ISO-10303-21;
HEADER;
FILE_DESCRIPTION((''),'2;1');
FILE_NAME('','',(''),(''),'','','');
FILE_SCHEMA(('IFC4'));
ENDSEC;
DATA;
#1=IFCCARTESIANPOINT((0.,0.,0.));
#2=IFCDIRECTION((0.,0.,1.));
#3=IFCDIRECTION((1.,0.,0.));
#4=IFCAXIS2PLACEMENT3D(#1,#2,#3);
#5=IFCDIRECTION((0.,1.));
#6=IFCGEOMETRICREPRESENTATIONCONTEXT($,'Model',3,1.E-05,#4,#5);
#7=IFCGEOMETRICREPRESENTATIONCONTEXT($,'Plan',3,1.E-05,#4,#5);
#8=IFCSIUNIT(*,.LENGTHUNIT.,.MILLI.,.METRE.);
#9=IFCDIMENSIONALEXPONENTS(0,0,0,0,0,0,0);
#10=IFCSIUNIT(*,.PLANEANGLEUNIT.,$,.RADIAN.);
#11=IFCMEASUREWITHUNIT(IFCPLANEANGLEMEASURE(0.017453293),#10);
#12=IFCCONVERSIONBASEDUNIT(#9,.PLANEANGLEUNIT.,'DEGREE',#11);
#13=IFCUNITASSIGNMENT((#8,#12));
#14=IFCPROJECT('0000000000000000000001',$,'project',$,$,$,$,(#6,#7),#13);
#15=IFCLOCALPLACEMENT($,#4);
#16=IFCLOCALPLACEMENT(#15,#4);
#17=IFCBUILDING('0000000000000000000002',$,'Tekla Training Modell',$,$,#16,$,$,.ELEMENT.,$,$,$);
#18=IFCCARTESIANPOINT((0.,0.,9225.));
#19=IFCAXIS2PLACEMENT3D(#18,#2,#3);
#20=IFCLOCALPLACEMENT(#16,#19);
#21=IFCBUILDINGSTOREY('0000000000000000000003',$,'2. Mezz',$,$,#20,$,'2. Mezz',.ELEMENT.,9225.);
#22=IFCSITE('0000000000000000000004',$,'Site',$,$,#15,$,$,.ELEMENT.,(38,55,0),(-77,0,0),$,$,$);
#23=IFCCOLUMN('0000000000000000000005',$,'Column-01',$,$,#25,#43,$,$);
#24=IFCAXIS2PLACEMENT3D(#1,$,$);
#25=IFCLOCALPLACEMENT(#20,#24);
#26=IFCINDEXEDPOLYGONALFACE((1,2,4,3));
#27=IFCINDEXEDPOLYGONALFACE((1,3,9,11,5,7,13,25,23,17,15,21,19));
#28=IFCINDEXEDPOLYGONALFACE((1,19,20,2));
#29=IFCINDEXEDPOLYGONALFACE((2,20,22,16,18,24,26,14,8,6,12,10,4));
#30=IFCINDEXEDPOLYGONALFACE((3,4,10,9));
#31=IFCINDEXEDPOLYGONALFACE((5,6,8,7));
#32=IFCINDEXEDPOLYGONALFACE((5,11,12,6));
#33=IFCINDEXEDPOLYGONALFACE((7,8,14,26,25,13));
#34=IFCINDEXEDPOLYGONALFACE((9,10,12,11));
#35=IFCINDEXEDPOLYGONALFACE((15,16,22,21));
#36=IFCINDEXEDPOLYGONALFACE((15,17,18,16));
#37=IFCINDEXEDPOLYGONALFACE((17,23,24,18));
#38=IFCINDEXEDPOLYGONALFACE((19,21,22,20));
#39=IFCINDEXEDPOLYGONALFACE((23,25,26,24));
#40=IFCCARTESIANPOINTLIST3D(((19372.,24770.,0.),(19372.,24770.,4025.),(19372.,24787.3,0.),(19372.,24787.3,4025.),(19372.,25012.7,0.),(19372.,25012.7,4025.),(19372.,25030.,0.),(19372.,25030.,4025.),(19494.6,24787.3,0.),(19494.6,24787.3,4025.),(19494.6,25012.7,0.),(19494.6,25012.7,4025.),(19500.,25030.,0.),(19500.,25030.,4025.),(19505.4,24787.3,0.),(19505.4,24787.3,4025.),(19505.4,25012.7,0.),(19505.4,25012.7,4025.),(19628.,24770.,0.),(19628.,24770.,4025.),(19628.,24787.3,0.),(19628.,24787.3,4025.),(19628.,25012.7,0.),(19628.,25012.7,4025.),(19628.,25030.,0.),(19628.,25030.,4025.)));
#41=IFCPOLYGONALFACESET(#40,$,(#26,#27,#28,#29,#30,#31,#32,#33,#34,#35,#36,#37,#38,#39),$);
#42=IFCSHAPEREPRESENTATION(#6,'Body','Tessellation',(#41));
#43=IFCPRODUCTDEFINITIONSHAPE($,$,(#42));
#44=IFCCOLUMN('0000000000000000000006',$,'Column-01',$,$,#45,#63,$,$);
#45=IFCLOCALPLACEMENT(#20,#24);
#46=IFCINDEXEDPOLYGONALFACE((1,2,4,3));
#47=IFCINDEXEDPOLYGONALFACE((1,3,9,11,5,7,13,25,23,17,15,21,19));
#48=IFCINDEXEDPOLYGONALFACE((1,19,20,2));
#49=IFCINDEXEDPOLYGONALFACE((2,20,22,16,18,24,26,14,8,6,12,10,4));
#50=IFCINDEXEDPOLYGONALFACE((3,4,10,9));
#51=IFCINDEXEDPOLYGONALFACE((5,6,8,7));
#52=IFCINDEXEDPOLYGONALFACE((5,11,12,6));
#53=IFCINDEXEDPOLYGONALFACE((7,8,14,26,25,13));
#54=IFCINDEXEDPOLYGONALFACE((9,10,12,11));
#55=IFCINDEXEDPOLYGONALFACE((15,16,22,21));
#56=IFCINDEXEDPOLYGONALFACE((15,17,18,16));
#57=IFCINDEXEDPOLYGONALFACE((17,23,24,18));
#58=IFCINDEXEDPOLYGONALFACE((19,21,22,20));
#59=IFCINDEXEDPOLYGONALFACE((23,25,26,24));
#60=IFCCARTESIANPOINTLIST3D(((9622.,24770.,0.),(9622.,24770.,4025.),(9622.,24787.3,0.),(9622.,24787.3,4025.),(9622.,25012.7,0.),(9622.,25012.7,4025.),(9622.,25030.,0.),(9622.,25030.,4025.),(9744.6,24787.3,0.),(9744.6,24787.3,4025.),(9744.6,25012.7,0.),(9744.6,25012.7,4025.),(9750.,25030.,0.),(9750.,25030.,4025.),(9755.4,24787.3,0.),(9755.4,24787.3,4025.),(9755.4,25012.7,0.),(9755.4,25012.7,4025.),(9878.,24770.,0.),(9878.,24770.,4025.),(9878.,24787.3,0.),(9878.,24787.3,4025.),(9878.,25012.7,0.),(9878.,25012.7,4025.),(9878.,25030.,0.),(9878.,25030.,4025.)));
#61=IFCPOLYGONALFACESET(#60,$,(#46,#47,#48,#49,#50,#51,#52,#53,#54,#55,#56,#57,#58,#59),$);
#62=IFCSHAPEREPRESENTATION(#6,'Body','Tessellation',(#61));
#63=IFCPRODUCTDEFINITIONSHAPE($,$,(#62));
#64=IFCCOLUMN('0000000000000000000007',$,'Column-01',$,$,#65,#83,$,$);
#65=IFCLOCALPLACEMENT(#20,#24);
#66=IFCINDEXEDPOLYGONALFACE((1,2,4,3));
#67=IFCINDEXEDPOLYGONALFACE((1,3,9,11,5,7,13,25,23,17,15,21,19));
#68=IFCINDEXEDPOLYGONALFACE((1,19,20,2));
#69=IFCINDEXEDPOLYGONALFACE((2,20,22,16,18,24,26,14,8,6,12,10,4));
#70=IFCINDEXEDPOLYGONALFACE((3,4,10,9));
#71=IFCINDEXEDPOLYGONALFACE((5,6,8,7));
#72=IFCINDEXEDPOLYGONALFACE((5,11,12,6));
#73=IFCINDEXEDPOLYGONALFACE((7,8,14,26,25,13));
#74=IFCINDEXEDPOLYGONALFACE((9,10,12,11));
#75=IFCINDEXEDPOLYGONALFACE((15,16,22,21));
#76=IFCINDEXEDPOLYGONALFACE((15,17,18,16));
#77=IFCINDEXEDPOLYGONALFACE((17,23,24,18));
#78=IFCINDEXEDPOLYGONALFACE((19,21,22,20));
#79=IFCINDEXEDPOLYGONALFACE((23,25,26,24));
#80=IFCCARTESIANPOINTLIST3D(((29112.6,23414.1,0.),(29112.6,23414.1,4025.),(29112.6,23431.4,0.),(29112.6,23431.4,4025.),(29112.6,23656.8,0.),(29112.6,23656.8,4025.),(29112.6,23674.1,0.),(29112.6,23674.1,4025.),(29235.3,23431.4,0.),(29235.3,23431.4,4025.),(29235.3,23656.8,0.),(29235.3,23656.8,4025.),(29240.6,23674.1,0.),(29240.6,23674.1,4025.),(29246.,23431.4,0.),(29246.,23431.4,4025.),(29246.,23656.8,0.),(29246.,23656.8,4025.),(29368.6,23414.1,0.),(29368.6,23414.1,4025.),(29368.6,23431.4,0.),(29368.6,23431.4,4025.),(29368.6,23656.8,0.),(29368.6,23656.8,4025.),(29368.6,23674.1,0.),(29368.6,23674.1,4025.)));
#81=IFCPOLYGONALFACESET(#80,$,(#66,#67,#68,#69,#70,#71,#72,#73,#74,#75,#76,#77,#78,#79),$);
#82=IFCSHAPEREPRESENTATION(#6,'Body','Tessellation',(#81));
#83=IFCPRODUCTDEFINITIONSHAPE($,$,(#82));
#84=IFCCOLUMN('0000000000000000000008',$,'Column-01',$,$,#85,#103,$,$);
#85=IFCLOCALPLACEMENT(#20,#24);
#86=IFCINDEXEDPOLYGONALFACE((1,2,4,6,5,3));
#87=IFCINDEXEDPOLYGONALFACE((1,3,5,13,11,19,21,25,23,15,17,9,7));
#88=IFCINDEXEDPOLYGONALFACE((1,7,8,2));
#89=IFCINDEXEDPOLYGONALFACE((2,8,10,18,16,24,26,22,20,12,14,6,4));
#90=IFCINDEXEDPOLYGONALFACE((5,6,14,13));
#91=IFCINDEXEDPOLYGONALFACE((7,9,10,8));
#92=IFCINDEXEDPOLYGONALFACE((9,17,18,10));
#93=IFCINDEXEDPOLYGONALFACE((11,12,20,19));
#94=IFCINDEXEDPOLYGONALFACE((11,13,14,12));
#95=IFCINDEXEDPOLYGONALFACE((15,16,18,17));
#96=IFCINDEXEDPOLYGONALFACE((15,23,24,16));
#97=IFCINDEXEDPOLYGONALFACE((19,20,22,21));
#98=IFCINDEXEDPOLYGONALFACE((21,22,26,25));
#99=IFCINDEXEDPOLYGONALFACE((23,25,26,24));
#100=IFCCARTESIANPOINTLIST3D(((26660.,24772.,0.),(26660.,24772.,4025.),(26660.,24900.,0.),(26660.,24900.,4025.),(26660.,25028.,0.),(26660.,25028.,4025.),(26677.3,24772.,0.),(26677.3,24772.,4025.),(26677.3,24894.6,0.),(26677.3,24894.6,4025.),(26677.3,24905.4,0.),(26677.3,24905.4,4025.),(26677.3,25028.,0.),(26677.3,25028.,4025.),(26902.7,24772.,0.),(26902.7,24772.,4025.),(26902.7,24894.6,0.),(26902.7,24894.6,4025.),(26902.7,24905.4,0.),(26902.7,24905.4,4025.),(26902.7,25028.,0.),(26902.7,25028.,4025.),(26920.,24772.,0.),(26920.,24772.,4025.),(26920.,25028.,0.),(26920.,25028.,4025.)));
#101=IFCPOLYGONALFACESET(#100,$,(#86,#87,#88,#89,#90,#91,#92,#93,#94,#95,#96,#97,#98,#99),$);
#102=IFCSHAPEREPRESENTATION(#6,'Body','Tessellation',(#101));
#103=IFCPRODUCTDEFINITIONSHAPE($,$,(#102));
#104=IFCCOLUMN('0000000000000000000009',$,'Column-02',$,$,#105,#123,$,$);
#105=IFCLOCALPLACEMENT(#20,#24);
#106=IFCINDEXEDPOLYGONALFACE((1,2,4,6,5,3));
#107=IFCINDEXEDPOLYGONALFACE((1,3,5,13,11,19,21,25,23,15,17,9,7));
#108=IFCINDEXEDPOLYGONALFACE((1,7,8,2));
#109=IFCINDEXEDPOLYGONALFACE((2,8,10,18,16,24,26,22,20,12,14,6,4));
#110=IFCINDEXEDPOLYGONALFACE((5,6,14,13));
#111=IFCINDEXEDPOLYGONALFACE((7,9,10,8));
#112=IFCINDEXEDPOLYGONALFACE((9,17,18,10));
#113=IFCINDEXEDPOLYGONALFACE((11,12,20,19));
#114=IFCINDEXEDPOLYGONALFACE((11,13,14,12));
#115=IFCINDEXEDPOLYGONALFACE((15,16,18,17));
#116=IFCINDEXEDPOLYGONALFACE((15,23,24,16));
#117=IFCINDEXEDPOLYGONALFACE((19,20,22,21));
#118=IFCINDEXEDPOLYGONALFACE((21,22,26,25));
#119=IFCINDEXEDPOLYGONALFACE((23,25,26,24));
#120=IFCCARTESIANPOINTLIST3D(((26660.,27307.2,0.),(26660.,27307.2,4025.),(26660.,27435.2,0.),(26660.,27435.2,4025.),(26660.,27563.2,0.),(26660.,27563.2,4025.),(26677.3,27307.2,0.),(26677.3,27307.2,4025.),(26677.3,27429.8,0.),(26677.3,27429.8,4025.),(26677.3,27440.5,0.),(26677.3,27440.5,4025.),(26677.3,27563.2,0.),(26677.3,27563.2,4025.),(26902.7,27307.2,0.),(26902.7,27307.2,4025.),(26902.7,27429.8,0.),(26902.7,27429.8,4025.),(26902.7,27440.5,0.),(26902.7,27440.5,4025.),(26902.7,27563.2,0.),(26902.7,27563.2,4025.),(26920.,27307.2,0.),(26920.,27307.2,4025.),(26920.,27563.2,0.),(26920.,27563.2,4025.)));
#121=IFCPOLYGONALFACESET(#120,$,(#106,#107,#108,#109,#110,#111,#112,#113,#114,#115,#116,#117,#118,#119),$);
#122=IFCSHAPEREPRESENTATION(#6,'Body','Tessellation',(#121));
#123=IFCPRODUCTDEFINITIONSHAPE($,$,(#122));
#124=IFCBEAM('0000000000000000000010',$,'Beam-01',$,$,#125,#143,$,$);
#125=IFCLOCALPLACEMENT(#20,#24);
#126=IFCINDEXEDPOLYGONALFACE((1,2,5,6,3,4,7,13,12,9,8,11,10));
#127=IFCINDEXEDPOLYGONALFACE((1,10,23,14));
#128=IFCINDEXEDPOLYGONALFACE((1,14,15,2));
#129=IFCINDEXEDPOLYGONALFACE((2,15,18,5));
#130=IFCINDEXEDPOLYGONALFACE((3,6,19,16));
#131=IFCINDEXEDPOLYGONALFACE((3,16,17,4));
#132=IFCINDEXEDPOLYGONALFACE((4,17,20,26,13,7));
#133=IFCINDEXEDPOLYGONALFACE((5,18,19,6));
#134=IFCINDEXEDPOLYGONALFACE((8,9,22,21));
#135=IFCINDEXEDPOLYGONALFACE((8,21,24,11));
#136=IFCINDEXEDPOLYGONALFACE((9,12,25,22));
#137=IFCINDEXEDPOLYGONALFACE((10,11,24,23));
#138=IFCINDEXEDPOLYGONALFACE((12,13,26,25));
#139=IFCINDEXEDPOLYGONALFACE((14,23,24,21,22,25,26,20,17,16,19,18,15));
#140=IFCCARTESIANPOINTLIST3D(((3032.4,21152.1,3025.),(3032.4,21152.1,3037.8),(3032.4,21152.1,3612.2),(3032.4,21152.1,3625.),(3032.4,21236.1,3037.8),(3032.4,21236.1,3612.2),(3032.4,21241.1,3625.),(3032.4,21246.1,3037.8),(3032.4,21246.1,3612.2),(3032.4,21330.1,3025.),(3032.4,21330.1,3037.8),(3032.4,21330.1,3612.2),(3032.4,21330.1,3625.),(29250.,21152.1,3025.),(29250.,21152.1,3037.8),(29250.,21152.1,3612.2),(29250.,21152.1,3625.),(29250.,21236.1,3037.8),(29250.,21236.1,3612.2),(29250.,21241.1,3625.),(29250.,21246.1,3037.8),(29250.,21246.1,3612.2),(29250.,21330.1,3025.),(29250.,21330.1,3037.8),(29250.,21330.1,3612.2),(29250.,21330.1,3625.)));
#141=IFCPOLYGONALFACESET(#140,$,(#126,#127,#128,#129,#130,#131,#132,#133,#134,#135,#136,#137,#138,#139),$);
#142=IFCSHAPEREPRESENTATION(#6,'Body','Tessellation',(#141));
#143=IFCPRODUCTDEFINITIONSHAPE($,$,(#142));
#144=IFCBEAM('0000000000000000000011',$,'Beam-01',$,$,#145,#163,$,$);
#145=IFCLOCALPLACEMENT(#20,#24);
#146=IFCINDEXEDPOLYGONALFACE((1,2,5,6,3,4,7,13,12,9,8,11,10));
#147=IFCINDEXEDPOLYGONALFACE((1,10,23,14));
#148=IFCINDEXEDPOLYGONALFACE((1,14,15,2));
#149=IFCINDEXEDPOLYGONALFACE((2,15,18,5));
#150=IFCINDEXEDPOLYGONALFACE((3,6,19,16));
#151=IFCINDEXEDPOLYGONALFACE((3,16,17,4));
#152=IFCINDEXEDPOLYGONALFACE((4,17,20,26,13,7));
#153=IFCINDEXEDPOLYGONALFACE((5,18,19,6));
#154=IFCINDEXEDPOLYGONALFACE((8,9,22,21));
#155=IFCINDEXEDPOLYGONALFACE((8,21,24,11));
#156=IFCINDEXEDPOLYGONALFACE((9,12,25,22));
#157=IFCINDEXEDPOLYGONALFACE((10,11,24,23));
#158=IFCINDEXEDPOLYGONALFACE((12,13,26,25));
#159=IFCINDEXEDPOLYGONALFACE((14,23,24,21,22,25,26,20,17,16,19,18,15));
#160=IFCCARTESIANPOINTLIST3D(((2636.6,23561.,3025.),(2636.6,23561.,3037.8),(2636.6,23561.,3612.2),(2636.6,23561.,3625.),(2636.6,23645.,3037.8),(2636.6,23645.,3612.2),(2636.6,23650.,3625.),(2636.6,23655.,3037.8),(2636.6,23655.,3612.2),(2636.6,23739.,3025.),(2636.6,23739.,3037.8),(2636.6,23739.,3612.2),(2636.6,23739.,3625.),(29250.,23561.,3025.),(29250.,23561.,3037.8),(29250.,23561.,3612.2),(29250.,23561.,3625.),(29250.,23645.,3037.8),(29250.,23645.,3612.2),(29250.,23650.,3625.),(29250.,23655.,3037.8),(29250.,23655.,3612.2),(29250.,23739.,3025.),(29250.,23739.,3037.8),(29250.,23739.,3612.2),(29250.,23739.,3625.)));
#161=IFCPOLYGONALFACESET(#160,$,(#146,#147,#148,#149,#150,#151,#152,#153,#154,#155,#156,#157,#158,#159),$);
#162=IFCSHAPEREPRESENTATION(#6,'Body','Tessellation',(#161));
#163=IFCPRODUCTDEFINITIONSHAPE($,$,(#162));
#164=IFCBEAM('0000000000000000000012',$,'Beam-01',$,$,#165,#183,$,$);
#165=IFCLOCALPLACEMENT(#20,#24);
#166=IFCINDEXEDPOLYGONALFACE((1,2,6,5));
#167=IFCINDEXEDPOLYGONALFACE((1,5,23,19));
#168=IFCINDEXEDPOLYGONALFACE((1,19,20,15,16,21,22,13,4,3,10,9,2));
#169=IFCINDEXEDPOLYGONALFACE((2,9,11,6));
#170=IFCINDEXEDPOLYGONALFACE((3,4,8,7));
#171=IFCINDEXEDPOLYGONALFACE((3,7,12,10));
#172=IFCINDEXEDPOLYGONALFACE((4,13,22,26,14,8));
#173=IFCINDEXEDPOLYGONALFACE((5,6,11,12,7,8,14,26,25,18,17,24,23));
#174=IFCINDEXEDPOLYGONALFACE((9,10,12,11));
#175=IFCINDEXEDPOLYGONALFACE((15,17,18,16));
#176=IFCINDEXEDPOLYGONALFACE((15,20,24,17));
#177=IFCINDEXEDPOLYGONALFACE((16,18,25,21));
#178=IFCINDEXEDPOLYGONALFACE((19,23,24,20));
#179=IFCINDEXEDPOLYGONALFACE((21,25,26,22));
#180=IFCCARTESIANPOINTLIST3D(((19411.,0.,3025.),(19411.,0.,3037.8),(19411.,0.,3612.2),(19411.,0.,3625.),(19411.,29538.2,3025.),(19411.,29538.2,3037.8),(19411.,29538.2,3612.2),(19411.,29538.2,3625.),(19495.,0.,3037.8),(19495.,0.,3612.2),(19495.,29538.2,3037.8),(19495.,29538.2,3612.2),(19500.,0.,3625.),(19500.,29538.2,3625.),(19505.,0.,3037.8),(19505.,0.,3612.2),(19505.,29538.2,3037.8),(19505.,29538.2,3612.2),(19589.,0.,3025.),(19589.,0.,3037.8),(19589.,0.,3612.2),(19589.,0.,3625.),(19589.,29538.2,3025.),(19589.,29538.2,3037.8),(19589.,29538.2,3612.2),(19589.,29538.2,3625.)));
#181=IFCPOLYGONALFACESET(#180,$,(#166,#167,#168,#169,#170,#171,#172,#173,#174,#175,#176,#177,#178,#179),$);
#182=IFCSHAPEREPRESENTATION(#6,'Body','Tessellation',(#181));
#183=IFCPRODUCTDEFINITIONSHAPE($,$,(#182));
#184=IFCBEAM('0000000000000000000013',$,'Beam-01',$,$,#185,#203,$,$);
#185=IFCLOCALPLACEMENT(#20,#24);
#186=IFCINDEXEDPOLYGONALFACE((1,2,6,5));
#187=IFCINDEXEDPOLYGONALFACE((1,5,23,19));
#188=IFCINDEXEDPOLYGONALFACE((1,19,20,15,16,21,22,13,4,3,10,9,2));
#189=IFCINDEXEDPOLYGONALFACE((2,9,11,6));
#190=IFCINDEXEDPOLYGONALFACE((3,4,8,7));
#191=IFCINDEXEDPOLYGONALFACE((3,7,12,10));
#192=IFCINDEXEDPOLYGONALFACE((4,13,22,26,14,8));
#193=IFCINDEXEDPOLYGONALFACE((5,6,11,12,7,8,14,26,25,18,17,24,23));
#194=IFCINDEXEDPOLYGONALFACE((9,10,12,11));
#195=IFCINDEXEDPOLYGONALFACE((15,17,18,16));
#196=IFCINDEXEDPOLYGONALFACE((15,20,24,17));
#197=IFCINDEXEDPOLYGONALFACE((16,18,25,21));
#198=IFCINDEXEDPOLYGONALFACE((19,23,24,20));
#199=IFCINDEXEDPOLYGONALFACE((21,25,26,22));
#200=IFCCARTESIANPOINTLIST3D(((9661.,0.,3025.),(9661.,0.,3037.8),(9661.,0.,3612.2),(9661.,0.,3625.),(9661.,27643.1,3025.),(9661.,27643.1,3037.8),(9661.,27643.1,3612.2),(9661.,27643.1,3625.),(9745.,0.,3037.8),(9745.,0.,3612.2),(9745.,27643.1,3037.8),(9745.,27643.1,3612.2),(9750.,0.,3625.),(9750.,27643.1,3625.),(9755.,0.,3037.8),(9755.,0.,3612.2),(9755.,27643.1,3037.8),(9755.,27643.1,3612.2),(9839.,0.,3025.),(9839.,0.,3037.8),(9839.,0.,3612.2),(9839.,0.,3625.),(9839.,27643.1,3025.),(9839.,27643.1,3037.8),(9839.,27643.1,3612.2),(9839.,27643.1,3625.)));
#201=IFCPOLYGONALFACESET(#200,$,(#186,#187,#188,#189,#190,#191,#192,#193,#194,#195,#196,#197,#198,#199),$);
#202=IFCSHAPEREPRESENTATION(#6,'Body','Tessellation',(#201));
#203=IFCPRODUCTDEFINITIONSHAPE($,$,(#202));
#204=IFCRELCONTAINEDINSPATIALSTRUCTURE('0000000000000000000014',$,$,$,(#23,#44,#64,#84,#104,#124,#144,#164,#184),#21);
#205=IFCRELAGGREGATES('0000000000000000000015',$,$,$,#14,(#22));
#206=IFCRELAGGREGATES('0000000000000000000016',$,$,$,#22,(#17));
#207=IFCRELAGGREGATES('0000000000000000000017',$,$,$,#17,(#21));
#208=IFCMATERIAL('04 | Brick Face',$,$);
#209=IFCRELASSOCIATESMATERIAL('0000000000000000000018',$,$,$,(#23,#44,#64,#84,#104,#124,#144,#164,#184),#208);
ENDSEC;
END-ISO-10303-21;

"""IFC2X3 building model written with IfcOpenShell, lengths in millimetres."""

from ifc_helpers import new_model, entity, si_unit, converted_unit, direction, frame, origin_with_axes, place, context, project, spatial, polyline, outline, extrude, material, element, save


model = new_model("IFC2X3")

# Units and contexts
model_context = context("Model", 3, precision=1e-05, world=origin_with_axes(), true_north=direction((0.0, 1.0)))
plan_context = context("Plan", 3, precision=1e-05, world=origin_with_axes(), true_north=direction((0.0, 1.0)))
ifc_project = project(units=[si_unit("LENGTHUNIT", "METRE", prefix="MILLI"), converted_unit("PLANEANGLEUNIT", "DEGREE", entity("IfcPlaneAngleMeasure", 0.017453293), si_unit("PLANEANGLEUNIT", "RADIAN"), dimensions=[0, 0, 0, 0, 0, 0, 0])], contexts=[model_context, plan_context])

# Site, building, storey
site_placement = place(None, origin_with_axes())
site = spatial("IfcSite", under=ifc_project, at=site_placement, Name="Site", CompositionType="ELEMENT", RefLatitude=(38, 55, 0), RefLongitude=(-77, 0, 0))
building_placement = place(site_placement, origin_with_axes())
building = spatial("IfcBuilding", under=site, at=building_placement, Name="Tekla Training Modell", CompositionType="ELEMENT")
storey_placement = place(building_placement, frame((0.0, 0.0, 9225.0), z_axis=(0.0, 0.0, 1.0), x_axis=(1.0, 0.0, 0.0)))
storey = spatial("IfcBuildingStorey", under=building, at=storey_placement, Name="2. Mezz", LongName="2. Mezz", CompositionType="ELEMENT", Elevation=9225.0)

# Columns
ifc_material_1 = material(Name="04 | Brick Face")
for number, where, z_axis, x_axis, name in (
    (1, (19500.0, 24900.0, 0.0), (0.0, 0.0, 1.0), (1.0, 0.0, 0.0), "Column-01"),
    (2, (9750.0, 24900.0, 0.0), (0.0, 0.0, 1.0), (1.0, 0.0, 0.0), "Column-01"),
    (3, (29240.6, 23544.1, 0.0), (0.0, 0.0, 1.0), (1.0, 0.0, 0.0), "Column-01"),
    (4, (26790.0, 24900.0, 0.0), (0.0, 0.0, 1.0), (0.0, 1.0, 0.0), "Column-01"),
    (5, (26790.0, 27435.2, 0.0), (0.0, 0.0, 1.0), (0.0, 1.0, 0.0), "Column-02"),
):
    element("IfcColumn", number, at=place(storey_placement, frame(where, z_axis=z_axis, x_axis=x_axis)), inside=storey, material=ifc_material_1, Name=name, context=model_context, shape_type="SweptSolid", body=[
        extrude(outline(polyline([(0.0, 130.0), (-128.0, 130.0), (-128.0, 112.7), (-5.3, 112.7), (-5.3, -112.7), (-128.0, -112.7), (-128.0, -130.0), (128.0, -130.0), (128.0, -112.7), (5.3, -112.7), (5.3, 112.7), (128.0, 112.7), (128.0, 130.0), (0.0, 130.0)])), origin_with_axes(), (0.0, 0.0, 1.0), 4025.0),
    ])

# Beams
beam_1_placement = place(storey_placement, frame((3032.4, 21241.1, 3325.0), z_axis=(0.0, 0.0, 1.0), x_axis=(0.0, -1.0, 0.0)))
element("IfcBeam", 6, at=beam_1_placement, inside=storey, material=ifc_material_1, Name="Beam-01", context=model_context, shape_type="SweptSolid", body=[
    extrude(outline(polyline([(0.0, 300.0), (-89.0, 300.0), (-89.0, 287.2), (-5.0, 287.2), (-5.0, -287.2), (-89.0, -287.2), (-89.0, -300.0), (89.0, -300.0), (89.0, -287.2), (5.0, -287.2), (5.0, 287.2), (89.0, 287.2), (89.0, 300.0), (0.0, 300.0)])), frame((0.0, 26217.6, 0.0), z_axis=(0.0, -1.0, 0.0), x_axis=(1.0, 0.0, 0.0)), (0.0, 0.0, 1.0), 26217.6),
])
beam_2_placement = place(storey_placement, frame((2636.6, 23650.0, 3325.0), z_axis=(0.0, 0.0, 1.0), x_axis=(0.0, -1.0, 0.0)))
element("IfcBeam", 7, at=beam_2_placement, inside=storey, material=ifc_material_1, Name="Beam-01", context=model_context, shape_type="SweptSolid", body=[
    extrude(outline(polyline([(0.0, 300.0), (-89.0, 300.0), (-89.0, 287.2), (-5.0, 287.2), (-5.0, -287.2), (-89.0, -287.2), (-89.0, -300.0), (89.0, -300.0), (89.0, -287.2), (5.0, -287.2), (5.0, 287.2), (89.0, 287.2), (89.0, 300.0), (0.0, 300.0)])), frame((0.0, 26613.4, 0.0), z_axis=(0.0, -1.0, 0.0), x_axis=(1.0, 0.0, 0.0)), (0.0, 0.0, 1.0), 26613.4),
])
beam_3_placement = place(storey_placement, frame((19500.0, 29538.2, 3325.0), z_axis=(0.0, 0.0, 1.0), x_axis=(-1.0, 0.0, 0.0)))
element("IfcBeam", 8, at=beam_3_placement, inside=storey, material=ifc_material_1, Name="Beam-01", context=model_context, shape_type="SweptSolid", body=[
    extrude(outline(polyline([(0.0, 300.0), (-89.0, 300.0), (-89.0, 287.2), (-5.0, 287.2), (-5.0, -287.2), (-89.0, -287.2), (-89.0, -300.0), (89.0, -300.0), (89.0, -287.2), (5.0, -287.2), (5.0, 287.2), (89.0, 287.2), (89.0, 300.0), (0.0, 300.0)])), frame((0.0, 29538.2, 0.0), z_axis=(0.0, -1.0, 0.0), x_axis=(1.0, 0.0, 0.0)), (0.0, 0.0, 1.0), 29538.2),
])
beam_4_placement = place(storey_placement, frame((9750.0, 27643.1, 3325.0), z_axis=(0.0, 0.0, 1.0), x_axis=(-1.0, 0.0, 0.0)))
element("IfcBeam", 9, at=beam_4_placement, inside=storey, material=ifc_material_1, Name="Beam-01", context=model_context, shape_type="SweptSolid", body=[
    extrude(outline(polyline([(0.0, 300.0), (-89.0, 300.0), (-89.0, 287.2), (-5.0, 287.2), (-5.0, -287.2), (-89.0, -287.2), (-89.0, -300.0), (89.0, -300.0), (89.0, -287.2), (5.0, -287.2), (5.0, 287.2), (89.0, 287.2), (89.0, 300.0), (0.0, 300.0)])), frame((0.0, 27643.1, 0.0), z_axis=(0.0, -1.0, 0.0), x_axis=(1.0, 0.0, 0.0)), (0.0, 0.0, 1.0), 27643.1),
])

save(model, "model.ifc")
